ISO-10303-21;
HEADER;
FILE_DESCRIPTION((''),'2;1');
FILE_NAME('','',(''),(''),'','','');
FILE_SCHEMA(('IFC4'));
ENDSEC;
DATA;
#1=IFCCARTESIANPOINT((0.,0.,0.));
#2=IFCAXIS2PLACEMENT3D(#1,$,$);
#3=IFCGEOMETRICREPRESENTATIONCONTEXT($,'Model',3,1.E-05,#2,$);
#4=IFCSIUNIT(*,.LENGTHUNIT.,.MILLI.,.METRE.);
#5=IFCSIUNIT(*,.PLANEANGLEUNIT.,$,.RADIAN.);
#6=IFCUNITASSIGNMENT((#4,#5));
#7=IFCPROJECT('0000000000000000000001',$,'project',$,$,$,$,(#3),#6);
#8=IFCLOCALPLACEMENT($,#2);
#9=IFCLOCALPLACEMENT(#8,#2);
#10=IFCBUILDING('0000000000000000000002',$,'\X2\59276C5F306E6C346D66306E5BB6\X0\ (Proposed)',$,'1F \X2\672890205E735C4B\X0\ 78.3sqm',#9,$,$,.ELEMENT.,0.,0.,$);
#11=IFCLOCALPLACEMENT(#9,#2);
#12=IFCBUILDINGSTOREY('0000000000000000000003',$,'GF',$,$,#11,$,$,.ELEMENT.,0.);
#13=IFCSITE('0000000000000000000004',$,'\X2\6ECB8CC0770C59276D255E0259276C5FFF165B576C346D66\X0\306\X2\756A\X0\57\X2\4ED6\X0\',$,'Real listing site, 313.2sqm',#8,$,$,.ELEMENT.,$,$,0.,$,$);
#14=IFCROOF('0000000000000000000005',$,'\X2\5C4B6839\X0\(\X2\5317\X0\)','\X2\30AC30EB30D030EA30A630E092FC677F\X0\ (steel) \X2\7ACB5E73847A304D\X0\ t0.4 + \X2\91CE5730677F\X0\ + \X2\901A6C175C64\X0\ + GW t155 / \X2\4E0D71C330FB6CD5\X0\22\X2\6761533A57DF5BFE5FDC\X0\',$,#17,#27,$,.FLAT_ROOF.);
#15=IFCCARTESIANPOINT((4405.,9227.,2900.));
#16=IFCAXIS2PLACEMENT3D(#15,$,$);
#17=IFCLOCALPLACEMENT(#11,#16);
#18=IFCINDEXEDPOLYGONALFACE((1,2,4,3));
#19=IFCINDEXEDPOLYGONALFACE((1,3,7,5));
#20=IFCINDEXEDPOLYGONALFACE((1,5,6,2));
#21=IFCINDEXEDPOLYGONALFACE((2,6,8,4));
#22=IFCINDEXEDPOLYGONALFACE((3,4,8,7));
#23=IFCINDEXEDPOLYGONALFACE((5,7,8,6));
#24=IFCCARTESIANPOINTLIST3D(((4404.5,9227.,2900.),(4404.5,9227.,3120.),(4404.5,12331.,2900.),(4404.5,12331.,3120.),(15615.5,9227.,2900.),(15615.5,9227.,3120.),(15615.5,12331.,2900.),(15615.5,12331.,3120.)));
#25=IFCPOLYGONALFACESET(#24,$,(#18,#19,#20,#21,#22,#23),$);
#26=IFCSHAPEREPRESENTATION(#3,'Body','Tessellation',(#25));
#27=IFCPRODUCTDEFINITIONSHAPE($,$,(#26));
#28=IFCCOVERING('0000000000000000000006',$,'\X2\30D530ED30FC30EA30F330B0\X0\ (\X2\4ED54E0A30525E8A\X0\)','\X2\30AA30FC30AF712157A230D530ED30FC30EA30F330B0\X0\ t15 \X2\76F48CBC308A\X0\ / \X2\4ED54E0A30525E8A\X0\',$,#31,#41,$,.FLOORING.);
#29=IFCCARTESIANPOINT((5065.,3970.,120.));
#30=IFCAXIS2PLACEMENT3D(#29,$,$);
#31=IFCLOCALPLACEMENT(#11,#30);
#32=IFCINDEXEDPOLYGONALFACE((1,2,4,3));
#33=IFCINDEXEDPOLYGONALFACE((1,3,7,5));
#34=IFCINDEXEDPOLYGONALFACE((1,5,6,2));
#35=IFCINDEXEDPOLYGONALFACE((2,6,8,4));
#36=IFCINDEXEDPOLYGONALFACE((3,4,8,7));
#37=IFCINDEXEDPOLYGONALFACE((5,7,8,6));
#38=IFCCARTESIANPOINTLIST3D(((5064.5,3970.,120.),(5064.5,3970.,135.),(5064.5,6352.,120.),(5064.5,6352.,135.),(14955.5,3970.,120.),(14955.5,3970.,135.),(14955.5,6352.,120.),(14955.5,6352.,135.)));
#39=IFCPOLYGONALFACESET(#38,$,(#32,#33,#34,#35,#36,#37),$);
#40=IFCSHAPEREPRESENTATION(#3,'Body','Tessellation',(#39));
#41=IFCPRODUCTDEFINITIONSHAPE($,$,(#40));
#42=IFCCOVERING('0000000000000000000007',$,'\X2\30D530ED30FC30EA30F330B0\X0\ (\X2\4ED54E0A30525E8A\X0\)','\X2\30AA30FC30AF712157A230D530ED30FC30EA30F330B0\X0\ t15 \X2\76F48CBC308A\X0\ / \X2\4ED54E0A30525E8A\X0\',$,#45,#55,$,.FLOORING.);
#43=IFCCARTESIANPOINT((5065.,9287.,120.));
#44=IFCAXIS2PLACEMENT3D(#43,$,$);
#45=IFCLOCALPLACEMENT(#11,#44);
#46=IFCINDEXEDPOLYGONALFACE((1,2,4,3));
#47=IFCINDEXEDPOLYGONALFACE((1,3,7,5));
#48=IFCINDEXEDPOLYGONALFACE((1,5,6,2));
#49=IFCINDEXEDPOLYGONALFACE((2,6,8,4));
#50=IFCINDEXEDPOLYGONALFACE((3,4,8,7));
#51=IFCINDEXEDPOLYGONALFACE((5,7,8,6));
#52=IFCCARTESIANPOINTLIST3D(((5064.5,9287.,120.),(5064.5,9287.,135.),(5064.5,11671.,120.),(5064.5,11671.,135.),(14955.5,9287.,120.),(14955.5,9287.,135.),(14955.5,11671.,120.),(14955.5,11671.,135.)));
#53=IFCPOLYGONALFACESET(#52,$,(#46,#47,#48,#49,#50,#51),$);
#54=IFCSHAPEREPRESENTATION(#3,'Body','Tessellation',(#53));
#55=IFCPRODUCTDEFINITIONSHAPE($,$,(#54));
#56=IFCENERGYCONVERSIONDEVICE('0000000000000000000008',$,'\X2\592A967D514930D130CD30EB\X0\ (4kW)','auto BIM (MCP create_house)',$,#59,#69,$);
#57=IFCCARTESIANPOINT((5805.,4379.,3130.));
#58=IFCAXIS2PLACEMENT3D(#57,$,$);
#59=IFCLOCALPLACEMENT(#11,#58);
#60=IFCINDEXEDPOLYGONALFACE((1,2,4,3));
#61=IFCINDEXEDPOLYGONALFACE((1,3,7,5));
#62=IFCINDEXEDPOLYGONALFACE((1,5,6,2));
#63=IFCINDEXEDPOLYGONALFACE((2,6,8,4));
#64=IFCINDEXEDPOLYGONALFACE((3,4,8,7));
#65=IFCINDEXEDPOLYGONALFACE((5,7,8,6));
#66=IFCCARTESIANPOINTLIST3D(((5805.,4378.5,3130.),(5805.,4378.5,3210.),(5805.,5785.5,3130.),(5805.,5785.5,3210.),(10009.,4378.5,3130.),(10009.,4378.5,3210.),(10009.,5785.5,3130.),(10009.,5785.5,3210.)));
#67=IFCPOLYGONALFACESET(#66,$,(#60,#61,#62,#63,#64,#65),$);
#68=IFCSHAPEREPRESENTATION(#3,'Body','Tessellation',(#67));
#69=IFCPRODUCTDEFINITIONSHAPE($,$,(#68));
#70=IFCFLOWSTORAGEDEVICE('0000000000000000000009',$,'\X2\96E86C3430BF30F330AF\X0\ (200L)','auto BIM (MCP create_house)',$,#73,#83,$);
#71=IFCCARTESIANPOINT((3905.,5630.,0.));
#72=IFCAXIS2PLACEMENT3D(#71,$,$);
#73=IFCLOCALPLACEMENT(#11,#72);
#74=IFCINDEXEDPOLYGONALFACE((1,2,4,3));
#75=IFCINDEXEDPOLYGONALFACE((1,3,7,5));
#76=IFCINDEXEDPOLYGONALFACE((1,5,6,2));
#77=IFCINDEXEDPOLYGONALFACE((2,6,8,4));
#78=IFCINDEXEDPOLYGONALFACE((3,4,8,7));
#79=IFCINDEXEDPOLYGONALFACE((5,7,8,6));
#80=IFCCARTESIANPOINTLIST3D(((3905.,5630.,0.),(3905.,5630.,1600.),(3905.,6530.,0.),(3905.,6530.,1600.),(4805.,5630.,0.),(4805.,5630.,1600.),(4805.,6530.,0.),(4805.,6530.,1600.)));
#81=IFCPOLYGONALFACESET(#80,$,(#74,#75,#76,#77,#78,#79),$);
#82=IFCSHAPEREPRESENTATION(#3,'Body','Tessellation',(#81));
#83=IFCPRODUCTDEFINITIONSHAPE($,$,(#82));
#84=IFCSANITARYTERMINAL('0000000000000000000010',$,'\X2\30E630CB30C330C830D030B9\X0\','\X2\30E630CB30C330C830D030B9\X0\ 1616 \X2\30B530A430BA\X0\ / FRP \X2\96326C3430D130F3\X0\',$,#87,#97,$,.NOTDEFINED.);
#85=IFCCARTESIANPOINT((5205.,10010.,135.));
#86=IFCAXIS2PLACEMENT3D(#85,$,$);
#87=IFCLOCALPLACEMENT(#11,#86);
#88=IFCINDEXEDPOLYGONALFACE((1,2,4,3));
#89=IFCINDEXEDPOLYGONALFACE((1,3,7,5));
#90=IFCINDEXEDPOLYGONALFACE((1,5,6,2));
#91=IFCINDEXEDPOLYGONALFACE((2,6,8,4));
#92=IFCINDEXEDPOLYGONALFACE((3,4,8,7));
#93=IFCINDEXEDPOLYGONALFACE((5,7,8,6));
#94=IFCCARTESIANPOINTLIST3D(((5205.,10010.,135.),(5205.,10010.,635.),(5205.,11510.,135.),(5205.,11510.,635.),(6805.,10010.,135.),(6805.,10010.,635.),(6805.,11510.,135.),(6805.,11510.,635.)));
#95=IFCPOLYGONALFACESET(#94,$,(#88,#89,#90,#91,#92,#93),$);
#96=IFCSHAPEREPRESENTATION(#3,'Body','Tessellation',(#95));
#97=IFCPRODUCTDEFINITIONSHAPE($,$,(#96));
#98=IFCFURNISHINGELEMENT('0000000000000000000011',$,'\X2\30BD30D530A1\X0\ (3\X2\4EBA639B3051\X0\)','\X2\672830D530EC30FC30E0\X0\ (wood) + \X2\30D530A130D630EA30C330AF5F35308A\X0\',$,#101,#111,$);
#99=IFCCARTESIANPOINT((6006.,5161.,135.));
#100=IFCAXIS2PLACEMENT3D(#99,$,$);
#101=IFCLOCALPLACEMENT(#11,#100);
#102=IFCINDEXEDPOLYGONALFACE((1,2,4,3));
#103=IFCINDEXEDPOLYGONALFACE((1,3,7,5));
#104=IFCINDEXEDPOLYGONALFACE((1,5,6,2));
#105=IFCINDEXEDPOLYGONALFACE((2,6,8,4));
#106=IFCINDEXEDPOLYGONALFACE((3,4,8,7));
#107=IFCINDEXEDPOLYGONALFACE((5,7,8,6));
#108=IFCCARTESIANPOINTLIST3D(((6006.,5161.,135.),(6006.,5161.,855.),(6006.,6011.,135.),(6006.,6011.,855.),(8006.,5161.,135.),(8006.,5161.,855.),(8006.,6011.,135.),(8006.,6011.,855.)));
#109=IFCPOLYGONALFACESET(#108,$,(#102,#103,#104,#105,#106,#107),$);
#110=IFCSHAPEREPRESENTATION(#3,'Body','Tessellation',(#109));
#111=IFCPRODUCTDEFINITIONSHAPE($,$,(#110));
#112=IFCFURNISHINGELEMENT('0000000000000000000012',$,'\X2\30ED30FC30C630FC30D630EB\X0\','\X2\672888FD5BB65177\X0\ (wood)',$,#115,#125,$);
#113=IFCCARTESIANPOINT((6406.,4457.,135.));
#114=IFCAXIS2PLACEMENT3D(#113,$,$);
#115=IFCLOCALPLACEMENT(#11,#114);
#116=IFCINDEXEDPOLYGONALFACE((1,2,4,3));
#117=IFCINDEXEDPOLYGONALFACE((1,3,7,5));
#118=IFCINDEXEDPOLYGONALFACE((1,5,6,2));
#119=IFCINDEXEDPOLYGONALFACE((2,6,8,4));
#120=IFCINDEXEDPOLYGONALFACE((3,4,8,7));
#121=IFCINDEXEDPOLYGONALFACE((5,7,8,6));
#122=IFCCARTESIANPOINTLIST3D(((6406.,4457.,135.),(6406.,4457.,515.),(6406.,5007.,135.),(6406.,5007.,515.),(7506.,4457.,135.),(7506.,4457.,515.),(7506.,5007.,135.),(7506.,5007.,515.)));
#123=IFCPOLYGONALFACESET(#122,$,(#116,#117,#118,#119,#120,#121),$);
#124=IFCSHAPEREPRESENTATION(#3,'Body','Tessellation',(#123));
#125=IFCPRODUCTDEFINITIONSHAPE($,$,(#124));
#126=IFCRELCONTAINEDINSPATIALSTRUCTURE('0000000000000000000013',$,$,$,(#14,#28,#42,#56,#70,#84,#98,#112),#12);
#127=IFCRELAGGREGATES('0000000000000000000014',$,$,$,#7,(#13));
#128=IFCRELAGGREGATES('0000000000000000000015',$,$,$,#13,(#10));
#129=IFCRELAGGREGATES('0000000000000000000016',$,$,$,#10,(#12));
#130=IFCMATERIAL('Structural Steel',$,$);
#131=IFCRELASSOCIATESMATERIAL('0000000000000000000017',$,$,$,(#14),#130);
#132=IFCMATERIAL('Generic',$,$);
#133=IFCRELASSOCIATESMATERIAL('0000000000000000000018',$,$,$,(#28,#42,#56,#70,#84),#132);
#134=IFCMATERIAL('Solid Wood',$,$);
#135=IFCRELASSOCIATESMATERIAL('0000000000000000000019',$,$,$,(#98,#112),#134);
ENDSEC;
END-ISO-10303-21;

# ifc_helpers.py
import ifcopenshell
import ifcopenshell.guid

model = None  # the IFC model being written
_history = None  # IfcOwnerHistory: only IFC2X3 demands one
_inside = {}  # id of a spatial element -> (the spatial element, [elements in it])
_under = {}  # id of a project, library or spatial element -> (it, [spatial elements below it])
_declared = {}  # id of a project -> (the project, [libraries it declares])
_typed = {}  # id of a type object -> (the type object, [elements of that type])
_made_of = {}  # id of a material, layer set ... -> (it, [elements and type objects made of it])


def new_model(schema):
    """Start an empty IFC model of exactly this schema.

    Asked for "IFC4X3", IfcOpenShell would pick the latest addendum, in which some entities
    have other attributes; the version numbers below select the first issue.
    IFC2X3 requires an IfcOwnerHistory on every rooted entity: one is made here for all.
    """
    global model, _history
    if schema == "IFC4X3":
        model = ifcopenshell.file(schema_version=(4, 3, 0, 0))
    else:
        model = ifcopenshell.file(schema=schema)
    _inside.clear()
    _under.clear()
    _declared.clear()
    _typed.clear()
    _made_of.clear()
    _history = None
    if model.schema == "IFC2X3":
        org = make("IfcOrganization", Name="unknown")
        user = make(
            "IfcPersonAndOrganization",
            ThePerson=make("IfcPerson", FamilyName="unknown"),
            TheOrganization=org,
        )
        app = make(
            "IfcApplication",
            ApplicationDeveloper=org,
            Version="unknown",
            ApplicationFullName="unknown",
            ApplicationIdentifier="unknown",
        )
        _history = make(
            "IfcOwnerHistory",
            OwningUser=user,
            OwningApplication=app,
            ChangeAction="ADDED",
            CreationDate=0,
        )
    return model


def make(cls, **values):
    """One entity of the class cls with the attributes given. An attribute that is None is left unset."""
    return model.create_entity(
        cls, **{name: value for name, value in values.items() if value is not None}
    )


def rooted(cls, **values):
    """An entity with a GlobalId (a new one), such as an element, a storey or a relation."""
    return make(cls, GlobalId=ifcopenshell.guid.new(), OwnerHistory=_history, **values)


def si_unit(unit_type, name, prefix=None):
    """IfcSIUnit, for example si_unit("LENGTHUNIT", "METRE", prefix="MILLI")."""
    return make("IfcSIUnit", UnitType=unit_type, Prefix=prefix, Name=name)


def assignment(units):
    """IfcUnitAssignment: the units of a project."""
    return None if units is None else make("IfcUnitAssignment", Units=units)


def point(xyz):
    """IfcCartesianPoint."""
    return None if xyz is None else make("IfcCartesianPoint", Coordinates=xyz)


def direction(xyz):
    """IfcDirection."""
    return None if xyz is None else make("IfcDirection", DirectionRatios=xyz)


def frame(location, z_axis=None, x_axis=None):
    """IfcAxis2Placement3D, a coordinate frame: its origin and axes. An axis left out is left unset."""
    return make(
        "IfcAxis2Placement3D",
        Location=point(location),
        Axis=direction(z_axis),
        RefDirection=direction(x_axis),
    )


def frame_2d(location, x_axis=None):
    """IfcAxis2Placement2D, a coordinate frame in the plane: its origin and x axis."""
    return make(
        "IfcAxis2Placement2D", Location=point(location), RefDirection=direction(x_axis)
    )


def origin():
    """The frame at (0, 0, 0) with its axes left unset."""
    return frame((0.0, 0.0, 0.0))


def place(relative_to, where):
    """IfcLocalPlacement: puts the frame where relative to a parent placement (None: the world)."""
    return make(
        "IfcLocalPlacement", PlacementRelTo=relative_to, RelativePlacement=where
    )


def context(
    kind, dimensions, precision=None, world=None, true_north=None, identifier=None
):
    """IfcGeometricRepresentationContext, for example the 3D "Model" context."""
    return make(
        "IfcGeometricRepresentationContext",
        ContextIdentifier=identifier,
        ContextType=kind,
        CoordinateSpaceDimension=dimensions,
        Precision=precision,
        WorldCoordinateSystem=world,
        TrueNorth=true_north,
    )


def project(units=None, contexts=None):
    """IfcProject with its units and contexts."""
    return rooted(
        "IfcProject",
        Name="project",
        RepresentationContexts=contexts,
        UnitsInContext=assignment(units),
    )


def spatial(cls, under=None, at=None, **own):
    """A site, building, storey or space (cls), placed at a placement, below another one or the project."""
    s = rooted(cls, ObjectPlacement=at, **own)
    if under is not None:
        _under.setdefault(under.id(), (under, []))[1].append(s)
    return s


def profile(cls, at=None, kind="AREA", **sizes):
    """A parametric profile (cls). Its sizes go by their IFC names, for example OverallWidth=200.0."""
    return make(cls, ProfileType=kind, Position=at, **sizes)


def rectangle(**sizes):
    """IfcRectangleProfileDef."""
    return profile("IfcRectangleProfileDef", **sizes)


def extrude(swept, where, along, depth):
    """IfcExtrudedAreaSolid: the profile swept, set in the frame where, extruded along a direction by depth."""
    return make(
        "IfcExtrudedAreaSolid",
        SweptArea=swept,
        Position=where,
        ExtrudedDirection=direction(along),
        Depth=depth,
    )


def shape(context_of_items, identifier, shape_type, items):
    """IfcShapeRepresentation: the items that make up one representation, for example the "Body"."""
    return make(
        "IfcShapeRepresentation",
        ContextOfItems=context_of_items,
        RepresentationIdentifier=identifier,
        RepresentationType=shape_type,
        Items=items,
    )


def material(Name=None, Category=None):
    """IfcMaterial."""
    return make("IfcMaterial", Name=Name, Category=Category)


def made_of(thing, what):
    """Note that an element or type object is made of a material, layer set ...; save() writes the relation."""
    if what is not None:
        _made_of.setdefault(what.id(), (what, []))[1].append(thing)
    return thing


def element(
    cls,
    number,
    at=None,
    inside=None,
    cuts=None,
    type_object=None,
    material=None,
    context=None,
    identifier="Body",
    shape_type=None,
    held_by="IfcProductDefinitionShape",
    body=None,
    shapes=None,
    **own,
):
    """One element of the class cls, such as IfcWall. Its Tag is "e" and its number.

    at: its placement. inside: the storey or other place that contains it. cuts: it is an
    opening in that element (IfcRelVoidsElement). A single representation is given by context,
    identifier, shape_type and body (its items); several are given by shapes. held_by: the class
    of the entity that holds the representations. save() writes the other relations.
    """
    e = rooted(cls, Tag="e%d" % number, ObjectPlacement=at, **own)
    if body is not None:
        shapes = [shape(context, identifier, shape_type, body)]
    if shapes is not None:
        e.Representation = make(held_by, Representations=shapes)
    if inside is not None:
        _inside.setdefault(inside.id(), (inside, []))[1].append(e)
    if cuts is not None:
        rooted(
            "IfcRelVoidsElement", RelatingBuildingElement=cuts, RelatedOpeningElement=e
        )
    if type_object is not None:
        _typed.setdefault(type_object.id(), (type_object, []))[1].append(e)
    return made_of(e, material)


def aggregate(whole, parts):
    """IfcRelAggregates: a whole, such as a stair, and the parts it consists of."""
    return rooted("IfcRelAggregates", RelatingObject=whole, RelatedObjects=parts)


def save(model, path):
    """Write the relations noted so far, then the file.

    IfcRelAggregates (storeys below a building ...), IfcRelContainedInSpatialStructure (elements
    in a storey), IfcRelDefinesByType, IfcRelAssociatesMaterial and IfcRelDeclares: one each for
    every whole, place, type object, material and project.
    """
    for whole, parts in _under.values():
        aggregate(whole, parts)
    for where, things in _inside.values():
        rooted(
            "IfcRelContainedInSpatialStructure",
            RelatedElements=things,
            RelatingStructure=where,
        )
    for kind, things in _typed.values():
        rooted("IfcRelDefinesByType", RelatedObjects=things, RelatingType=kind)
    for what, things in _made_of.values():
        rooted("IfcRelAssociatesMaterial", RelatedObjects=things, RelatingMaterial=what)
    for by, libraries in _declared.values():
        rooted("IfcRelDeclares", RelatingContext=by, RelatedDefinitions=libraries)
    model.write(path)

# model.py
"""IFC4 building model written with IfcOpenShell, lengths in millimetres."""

from ifc_helpers import new_model, si_unit, frame, frame_2d, origin, place, context, project, spatial, rectangle, extrude, material, element, save


model = new_model("IFC4")

# Units and contexts
model_context = context("Model", 3, precision=1e-05, world=origin())
ifc_project = project(units=[si_unit("LENGTHUNIT", "METRE", prefix="MILLI"), si_unit("PLANEANGLEUNIT", "RADIAN")], contexts=[model_context])

# Site, building, storey
site_placement = place(None, origin())
site = spatial("IfcSite", under=ifc_project, at=site_placement, Name="滋賀県大津市大江６字水浦306番57他", ObjectType="Real listing site, 313.2sqm", CompositionType="ELEMENT", RefElevation=0.0)
building_placement = place(site_placement, origin())
building = spatial("IfcBuilding", under=site, at=building_placement, Name="大江の水浦の家 (Proposed)", ObjectType="1F 木造平屋 78.3sqm", CompositionType="ELEMENT", ElevationOfRefHeight=0.0, ElevationOfTerrain=0.0)
storey_placement = place(building_placement, origin())
storey = spatial("IfcBuildingStorey", under=building, at=storey_placement, Name="GF", CompositionType="ELEMENT", Elevation=0.0)

# Shared definitions
ifc_material_1 = material(Name="Solid Wood")

# Roof
ifc_material_2 = material(Name="Structural Steel")
roof_1_placement = place(storey_placement, frame((4405.0, 9227.0, 2900.0)))
element("IfcRoof", 1, at=roof_1_placement, inside=storey, material=ifc_material_2, Name="屋根(北)", Description="ガルバリウム鋼板 (steel) 立平葺き t0.4 + 野地板 + 通気層 + GW t155 / 不燃・法22条区域対応", PredefinedType="FLAT_ROOF", context=model_context, shape_type="SweptSolid", body=[
    extrude(rectangle(XDim=11211.0, YDim=3104.0, at=frame_2d((5605.0, 1552.0))), frame((4405.0, 9227.0, 2900.0)), (0.0, 0.0, 1.0), 220.0),
])

# Coverings
ifc_material_3 = material(Name="Generic")
covering_1_placement = place(storey_placement, frame((5065.0, 3970.0, 120.0)))
element("IfcCovering", 2, at=covering_1_placement, inside=storey, material=ifc_material_3, Name="フローリング (仕上げ床)", Description="オーク無垢フローリング t15 直貼り / 仕上げ床", PredefinedType="FLOORING", context=model_context, shape_type="SweptSolid", body=[
    extrude(rectangle(XDim=9891.0, YDim=2382.0, at=frame_2d((4945.0, 1191.0))), frame((5065.0, 3970.0, 120.0)), (0.0, 0.0, 1.0), 15.0),
])
covering_2_placement = place(storey_placement, frame((5065.0, 9287.0, 120.0)))
element("IfcCovering", 3, at=covering_2_placement, inside=storey, material=ifc_material_3, Name="フローリング (仕上げ床)", Description="オーク無垢フローリング t15 直貼り / 仕上げ床", PredefinedType="FLOORING", context=model_context, shape_type="SweptSolid", body=[
    extrude(rectangle(XDim=9891.0, YDim=2384.0, at=frame_2d((4945.0, 1192.0))), frame((5065.0, 9287.0, 120.0)), (0.0, 0.0, 1.0), 15.0),
])

# Energy conversion device
energy_conversion_device_placement = place(storey_placement, frame((5805.0, 4379.0, 3130.0)))
element("IfcEnergyConversionDevice", 4, at=energy_conversion_device_placement, inside=storey, material=ifc_material_3, Name="太陽光パネル (4kW)", Description="auto BIM (MCP create_house)", context=model_context, shape_type="SweptSolid", body=[
    extrude(rectangle(XDim=4204.0, YDim=1407.0, at=frame_2d((2102.0, 703.0))), frame((5805.0, 4379.0, 3130.0)), (0.0, 0.0, 1.0), 80.0),
])

# Flow storage device
flow_storage_device_placement = place(storey_placement, frame((3905.0, 5630.0, 0.0)))
element("IfcFlowStorageDevice", 5, at=flow_storage_device_placement, inside=storey, material=ifc_material_3, Name="雨水タンク (200L)", Description="auto BIM (MCP create_house)", context=model_context, shape_type="SweptSolid", body=[
    extrude(rectangle(XDim=900.0, YDim=900.0, at=frame_2d((450.0, 450.0))), frame((3905.0, 5630.0, 0.0)), (0.0, 0.0, 1.0), 1600.0),
])

# Sanitary terminal
sanitary_terminal_placement = place(storey_placement, frame((5205.0, 10010.0, 135.0)))
element("IfcSanitaryTerminal", 6, at=sanitary_terminal_placement, inside=storey, material=ifc_material_3, Name="ユニットバス", Description="ユニットバス 1616 サイズ / FRP 防水パン", PredefinedType="NOTDEFINED", context=model_context, shape_type="SweptSolid", body=[
    extrude(rectangle(XDim=1600.0, YDim=1500.0, at=frame_2d((800.0, 750.0))), frame((5205.0, 10010.0, 135.0)), (0.0, 0.0, 1.0), 500.0),
])

# Furnishing elements
furnishing_1_placement = place(storey_placement, frame((6006.0, 5161.0, 135.0)))
element("IfcFurnishingElement", 7, at=furnishing_1_placement, inside=storey, material=ifc_material_1, Name="ソファ (3人掛け)", Description="木フレーム (wood) + ファブリック張り", context=model_context, shape_type="SweptSolid", body=[
    extrude(rectangle(XDim=2000.0, YDim=850.0, at=frame_2d((1000.0, 425.0))), frame((6006.0, 5161.0, 135.0)), (0.0, 0.0, 1.0), 720.0),
])
furnishing_2_placement = place(storey_placement, frame((6406.0, 4457.0, 135.0)))
element("IfcFurnishingElement", 8, at=furnishing_2_placement, inside=storey, material=ifc_material_1, Name="ローテーブル", Description="木製家具 (wood)", context=model_context, shape_type="SweptSolid", body=[
    extrude(rectangle(XDim=1100.0, YDim=550.0, at=frame_2d((550.0, 275.0))), frame((6406.0, 4457.0, 135.0)), (0.0, 0.0, 1.0), 380.0),
])

save(model, "model.ifc")
